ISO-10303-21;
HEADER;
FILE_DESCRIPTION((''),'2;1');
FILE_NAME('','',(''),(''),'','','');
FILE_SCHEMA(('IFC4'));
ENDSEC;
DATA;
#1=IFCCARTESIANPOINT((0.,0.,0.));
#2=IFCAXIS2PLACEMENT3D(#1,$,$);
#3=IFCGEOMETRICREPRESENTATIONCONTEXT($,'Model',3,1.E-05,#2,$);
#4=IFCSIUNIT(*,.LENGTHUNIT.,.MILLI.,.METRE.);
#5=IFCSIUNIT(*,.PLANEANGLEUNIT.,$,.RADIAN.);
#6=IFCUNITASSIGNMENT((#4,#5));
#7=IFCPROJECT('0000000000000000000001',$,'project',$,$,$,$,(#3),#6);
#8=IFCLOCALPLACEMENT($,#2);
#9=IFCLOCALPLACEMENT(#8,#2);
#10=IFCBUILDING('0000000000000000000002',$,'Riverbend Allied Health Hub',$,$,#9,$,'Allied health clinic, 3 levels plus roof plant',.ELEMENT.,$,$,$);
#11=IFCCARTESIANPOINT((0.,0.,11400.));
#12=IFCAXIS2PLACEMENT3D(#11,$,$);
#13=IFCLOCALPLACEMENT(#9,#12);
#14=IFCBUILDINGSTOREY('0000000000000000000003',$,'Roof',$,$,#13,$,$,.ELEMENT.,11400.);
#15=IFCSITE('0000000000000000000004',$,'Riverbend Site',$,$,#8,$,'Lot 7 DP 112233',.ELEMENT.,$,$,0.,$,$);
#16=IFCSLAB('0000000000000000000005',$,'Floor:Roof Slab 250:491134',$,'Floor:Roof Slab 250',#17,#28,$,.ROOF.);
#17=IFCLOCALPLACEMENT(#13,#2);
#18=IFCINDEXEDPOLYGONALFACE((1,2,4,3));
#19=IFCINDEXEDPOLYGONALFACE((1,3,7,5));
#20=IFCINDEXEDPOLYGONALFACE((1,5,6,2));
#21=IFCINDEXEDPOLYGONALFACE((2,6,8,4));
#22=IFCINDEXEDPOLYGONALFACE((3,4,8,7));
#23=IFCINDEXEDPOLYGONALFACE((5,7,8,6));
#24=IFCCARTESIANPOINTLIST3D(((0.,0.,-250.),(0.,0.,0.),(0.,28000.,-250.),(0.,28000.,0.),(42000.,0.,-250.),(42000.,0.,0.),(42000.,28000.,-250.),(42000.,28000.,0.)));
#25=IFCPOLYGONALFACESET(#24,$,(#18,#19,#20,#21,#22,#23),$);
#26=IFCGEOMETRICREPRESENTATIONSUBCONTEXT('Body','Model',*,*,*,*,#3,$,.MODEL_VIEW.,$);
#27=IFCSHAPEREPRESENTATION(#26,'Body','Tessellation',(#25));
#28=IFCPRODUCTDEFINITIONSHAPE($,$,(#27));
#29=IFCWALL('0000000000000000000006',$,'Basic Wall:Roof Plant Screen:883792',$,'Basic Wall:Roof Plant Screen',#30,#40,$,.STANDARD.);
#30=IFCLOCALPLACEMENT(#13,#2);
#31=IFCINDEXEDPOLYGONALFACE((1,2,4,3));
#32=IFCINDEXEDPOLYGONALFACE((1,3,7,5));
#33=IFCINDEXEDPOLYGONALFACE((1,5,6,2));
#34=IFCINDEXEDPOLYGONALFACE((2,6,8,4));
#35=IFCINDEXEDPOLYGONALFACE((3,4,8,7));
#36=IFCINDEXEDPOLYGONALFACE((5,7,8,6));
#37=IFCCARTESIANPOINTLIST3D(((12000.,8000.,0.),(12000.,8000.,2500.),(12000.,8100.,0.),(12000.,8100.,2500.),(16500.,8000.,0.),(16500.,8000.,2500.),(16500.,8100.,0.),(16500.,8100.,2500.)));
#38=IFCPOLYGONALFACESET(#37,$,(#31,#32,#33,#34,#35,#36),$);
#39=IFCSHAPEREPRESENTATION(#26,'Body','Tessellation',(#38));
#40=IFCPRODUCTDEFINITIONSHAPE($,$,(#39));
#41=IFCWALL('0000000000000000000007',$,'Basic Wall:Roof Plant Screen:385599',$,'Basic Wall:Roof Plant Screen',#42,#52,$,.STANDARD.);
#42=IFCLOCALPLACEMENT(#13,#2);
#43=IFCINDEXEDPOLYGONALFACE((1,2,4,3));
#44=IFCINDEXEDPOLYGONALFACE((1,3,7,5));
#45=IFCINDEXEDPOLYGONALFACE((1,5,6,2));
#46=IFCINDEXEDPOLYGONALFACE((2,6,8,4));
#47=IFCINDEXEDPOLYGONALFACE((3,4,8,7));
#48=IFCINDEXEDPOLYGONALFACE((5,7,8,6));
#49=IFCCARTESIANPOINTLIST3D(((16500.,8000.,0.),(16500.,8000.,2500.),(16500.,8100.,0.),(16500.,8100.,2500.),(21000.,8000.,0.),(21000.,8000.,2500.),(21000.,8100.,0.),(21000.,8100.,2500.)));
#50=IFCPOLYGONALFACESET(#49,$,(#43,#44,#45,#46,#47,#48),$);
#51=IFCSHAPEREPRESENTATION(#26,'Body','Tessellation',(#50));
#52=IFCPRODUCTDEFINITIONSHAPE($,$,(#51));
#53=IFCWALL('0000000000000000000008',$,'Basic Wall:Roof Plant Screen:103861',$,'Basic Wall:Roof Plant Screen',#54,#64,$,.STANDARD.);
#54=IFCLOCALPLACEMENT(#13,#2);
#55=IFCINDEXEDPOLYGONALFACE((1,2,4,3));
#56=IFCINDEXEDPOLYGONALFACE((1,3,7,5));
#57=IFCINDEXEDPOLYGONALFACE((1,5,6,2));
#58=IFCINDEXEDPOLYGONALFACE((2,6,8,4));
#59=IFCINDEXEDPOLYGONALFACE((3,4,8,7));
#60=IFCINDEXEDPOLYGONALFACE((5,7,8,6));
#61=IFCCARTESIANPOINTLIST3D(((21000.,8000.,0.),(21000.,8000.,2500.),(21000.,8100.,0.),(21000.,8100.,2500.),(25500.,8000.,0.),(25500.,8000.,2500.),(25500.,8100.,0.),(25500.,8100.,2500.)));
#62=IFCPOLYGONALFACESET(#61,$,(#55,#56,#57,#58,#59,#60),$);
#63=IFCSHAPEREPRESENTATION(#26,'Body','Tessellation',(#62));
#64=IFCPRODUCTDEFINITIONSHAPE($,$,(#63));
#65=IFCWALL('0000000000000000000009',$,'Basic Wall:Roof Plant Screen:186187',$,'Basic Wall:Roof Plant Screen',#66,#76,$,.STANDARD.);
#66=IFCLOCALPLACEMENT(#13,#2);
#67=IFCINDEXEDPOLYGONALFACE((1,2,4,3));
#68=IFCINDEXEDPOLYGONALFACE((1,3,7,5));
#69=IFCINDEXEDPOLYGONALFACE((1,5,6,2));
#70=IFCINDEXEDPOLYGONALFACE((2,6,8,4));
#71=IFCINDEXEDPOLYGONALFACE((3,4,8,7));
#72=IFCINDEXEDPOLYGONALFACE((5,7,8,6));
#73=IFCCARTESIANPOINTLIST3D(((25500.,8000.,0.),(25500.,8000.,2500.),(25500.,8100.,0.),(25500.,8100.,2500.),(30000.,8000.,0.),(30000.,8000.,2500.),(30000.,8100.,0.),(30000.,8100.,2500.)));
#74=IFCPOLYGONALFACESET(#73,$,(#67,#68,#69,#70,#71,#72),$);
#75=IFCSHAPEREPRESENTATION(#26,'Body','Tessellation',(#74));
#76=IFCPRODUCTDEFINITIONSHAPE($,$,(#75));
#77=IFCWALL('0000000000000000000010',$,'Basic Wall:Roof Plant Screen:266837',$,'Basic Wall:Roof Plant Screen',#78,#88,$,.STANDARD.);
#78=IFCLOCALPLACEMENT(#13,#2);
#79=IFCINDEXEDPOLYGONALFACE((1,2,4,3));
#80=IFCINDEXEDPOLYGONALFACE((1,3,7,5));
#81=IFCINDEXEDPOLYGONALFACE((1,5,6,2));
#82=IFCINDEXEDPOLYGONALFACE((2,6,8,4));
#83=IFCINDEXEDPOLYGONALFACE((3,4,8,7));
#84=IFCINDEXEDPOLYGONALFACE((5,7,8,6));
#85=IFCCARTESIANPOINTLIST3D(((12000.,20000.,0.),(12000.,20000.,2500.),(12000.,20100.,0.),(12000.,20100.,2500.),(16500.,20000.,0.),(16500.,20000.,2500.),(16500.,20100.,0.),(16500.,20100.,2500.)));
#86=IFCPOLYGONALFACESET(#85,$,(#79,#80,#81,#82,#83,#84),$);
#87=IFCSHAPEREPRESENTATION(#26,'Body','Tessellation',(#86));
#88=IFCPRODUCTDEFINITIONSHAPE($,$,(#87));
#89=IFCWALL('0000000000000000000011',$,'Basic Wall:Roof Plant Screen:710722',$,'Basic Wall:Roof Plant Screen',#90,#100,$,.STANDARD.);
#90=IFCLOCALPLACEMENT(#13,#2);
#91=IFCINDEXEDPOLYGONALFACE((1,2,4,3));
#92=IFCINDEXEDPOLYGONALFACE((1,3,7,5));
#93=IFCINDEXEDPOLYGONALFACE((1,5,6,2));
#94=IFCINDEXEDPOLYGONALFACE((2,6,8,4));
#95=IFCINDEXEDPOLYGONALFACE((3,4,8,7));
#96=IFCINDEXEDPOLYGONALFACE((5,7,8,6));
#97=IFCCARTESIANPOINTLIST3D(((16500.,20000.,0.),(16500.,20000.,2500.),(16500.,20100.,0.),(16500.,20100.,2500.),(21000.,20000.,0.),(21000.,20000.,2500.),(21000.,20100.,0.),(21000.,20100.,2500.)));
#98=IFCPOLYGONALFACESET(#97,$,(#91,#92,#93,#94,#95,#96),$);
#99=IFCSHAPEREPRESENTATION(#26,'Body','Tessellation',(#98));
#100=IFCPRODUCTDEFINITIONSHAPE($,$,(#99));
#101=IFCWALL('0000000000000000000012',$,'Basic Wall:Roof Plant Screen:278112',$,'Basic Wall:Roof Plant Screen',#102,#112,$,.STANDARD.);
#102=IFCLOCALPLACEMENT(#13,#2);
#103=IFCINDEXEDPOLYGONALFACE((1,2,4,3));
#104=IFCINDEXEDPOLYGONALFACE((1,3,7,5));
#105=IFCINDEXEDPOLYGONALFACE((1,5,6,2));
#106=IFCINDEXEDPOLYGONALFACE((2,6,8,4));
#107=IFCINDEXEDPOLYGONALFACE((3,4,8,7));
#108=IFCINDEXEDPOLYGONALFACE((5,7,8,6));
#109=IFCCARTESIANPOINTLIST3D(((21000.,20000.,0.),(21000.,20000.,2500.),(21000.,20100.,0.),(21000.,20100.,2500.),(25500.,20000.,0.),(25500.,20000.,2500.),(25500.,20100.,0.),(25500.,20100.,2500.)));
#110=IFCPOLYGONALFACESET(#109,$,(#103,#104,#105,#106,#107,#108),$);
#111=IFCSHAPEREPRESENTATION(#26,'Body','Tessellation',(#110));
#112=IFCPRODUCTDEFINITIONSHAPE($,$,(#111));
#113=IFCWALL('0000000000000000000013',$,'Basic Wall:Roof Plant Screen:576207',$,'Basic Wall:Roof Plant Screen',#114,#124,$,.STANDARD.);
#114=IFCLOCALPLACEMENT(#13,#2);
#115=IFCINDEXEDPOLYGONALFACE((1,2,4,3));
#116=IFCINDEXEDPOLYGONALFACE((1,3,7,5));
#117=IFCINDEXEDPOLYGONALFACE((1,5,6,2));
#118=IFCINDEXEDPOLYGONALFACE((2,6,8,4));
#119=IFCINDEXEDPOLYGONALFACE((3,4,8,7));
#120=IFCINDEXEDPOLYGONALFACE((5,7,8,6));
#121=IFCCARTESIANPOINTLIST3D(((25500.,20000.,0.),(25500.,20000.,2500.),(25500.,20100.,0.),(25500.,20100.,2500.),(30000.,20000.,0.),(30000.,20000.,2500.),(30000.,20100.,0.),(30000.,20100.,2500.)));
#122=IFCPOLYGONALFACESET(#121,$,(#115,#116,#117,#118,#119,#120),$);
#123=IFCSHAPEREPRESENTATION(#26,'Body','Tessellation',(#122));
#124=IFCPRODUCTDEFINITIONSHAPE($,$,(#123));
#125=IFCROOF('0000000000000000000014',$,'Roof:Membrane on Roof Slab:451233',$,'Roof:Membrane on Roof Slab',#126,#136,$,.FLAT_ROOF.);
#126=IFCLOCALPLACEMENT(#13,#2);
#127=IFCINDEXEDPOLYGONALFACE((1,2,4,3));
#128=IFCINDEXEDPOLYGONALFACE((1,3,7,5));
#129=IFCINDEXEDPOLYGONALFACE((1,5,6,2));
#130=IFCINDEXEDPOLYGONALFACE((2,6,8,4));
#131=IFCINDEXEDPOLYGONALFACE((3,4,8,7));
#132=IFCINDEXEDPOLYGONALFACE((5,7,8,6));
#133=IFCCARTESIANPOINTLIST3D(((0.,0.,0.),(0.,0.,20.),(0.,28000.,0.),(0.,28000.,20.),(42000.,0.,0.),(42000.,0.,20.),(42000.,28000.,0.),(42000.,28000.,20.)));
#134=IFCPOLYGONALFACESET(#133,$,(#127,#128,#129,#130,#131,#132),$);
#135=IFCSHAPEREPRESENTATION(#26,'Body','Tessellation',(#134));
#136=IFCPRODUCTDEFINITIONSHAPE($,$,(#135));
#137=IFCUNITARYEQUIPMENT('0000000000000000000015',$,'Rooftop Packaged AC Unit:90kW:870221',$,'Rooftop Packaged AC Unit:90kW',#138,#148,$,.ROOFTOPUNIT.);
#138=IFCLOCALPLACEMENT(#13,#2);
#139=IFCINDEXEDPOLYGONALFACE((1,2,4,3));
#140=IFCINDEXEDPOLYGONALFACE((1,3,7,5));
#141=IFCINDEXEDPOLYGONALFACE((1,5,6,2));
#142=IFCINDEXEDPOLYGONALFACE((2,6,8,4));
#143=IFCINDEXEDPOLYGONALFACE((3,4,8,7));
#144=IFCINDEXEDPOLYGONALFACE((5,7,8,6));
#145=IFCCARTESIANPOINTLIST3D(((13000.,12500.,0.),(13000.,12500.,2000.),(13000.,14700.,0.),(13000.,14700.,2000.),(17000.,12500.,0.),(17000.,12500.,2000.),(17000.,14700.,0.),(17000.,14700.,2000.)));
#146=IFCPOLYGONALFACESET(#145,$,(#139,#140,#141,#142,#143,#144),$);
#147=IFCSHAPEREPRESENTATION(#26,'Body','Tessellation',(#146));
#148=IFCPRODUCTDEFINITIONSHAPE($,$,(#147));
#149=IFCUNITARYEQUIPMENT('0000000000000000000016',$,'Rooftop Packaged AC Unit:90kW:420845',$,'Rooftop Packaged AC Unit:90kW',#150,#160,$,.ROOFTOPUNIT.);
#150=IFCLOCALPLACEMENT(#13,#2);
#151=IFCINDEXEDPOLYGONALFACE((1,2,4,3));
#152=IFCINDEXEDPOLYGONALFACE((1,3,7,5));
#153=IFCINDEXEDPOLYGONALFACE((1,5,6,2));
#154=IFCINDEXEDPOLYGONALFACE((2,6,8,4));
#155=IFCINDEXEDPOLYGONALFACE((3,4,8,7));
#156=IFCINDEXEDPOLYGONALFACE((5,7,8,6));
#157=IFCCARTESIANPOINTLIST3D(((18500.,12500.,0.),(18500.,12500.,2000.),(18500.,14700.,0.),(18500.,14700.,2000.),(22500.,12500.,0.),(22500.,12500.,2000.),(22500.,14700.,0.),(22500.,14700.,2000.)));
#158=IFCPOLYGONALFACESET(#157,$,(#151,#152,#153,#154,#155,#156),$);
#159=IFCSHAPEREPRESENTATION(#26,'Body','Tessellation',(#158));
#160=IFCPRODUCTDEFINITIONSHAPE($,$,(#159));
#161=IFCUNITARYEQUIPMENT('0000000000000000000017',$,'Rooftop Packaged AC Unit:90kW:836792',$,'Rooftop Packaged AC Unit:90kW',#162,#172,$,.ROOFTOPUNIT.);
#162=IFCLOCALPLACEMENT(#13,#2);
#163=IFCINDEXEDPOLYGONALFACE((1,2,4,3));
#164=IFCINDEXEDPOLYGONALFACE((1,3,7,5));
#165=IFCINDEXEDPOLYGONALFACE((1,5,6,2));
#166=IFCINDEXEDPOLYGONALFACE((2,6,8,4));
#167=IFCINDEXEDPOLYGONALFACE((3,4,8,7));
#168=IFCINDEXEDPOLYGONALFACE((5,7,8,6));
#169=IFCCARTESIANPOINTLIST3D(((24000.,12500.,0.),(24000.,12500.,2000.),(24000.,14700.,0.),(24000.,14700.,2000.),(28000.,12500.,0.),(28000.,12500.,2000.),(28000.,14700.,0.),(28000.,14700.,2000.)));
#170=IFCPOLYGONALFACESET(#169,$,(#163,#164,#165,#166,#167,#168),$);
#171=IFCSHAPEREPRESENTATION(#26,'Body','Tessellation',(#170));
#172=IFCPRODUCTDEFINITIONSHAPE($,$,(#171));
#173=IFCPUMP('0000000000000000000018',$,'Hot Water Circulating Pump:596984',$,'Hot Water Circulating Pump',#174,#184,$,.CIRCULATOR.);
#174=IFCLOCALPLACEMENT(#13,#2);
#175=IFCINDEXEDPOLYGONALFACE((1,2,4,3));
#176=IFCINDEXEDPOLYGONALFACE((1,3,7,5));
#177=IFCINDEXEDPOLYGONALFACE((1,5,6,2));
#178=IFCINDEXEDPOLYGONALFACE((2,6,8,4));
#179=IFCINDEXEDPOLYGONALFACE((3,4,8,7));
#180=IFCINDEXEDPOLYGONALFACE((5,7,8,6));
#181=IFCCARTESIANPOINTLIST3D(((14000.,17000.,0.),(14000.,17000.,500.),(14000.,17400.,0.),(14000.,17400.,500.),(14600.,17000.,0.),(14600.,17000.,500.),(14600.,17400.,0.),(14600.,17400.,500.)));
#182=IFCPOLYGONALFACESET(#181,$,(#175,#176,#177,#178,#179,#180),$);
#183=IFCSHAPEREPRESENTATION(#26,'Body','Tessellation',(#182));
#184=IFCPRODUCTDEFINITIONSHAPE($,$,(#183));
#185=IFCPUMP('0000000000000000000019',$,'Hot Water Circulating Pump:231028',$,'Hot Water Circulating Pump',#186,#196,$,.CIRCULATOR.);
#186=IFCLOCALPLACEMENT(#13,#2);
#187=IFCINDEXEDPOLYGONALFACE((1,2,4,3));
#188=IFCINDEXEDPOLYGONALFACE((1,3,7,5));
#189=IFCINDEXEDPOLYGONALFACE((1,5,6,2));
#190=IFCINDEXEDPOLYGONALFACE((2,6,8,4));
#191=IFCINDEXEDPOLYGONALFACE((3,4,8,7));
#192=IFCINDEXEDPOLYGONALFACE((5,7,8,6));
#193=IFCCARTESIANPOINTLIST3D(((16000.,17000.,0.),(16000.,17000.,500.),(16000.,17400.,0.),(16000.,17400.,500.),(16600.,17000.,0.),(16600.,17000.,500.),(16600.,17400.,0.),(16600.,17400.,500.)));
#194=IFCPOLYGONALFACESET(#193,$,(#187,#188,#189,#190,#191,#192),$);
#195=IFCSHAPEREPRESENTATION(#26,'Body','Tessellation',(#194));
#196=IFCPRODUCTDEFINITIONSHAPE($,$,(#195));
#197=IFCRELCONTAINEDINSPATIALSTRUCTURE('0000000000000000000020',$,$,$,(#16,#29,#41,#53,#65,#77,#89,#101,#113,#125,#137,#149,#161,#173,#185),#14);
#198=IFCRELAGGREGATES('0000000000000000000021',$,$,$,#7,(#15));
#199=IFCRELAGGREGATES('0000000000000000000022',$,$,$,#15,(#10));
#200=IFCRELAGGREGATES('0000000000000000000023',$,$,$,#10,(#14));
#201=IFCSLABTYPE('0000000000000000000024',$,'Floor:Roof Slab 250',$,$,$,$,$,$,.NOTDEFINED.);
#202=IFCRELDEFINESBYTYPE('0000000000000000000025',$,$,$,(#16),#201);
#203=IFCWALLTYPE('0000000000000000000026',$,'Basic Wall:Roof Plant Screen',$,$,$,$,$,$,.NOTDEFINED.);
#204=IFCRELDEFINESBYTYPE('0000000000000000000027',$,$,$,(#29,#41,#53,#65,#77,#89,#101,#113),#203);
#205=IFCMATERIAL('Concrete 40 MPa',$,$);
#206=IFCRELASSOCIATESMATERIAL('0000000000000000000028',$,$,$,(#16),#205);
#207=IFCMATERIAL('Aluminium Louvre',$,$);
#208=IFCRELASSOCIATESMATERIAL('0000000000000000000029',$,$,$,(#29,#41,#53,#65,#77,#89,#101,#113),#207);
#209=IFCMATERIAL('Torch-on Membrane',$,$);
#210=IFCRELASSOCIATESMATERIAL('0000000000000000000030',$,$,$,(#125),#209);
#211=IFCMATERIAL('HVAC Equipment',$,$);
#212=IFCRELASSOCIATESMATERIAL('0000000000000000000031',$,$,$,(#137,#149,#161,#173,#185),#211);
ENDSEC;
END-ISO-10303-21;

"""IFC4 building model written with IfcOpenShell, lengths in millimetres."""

from ifc_helpers import new_model, si_unit, frame, frame_2d, origin, place, context, subcontext, project, spatial, rectangle, extrude, material, type_object, element, save


model = new_model("IFC4")

# Units and contexts
model_context = context("Model", 3, precision=1e-05, world=origin())
body_context = subcontext(model_context, "Body", "Model", "MODEL_VIEW")
ifc_project = project(units=[si_unit("LENGTHUNIT", "METRE", prefix="MILLI"), si_unit("PLANEANGLEUNIT", "RADIAN")], contexts=[model_context])

# Site, building, storey
site_placement = place(None, origin())
site = spatial("IfcSite", under=ifc_project, at=site_placement, Name="Riverbend Site", LongName="Lot 7 DP 112233", CompositionType="ELEMENT", RefElevation=0.0)
building_placement = place(site_placement, origin())
building = spatial("IfcBuilding", under=site, at=building_placement, Name="Riverbend Allied Health Hub", LongName="Allied health clinic, 3 levels plus roof plant", CompositionType="ELEMENT")
storey_placement = place(building_placement, frame((0.0, 0.0, 11400.0)))
storey = spatial("IfcBuildingStorey", under=building, at=storey_placement, Name="Roof", CompositionType="ELEMENT", Elevation=11400.0)

# Slab
ifc_material_1 = material(Name="Concrete 40 MPa")
slab_type = type_object("IfcSlabType", Name="Floor:Roof Slab 250", PredefinedType="NOTDEFINED")
slab_placement = place(storey_placement, frame((0.0, 0.0, -250.0)))
element("IfcSlab", 1, at=slab_placement, inside=storey, type_object=slab_type, material=ifc_material_1, Name="Floor:Roof Slab 250:491134", ObjectType="Floor:Roof Slab 250", PredefinedType="ROOF", context=body_context, shape_type="SweptSolid", body=[
    extrude(rectangle(XDim=42000.0, YDim=28000.0, at=frame_2d((21000.0, 14000.0))), origin(), (0.0, 0.0, 1.0), 250.0),
])

# Walls
ifc_material_2 = material(Name="Aluminium Louvre")
wall_type = type_object("IfcWallType", Name="Basic Wall:Roof Plant Screen", PredefinedType="NOTDEFINED")
for number, where, name in (
    (2, (12000.0, 8000.0, 0.0), "Basic Wall:Roof Plant Screen:883792"),
    (3, (16500.0, 8000.0, 0.0), "Basic Wall:Roof Plant Screen:385599"),
    (4, (21000.0, 8000.0, 0.0), "Basic Wall:Roof Plant Screen:103861"),
    (5, (25500.0, 8000.0, 0.0), "Basic Wall:Roof Plant Screen:186187"),
    (6, (12000.0, 20000.0, 0.0), "Basic Wall:Roof Plant Screen:266837"),
    (7, (16500.0, 20000.0, 0.0), "Basic Wall:Roof Plant Screen:710722"),
    (8, (21000.0, 20000.0, 0.0), "Basic Wall:Roof Plant Screen:278112"),
    (9, (25500.0, 20000.0, 0.0), "Basic Wall:Roof Plant Screen:576207"),
):
    element("IfcWall", number, at=place(storey_placement, frame(where)), inside=storey, type_object=wall_type, material=ifc_material_2, Name=name, ObjectType="Basic Wall:Roof Plant Screen", PredefinedType="STANDARD", context=body_context, shape_type="SweptSolid", body=[
        extrude(rectangle(XDim=4500.0, YDim=100.0, at=frame_2d((2250.0, 50.0))), origin(), (0.0, 0.0, 1.0), 2500.0),
    ])

# Roof
ifc_material_3 = material(Name="Torch-on Membrane")
roof_placement = place(storey_placement, origin())
element("IfcRoof", 10, at=roof_placement, inside=storey, material=ifc_material_3, Name="Roof:Membrane on Roof Slab:451233", ObjectType="Roof:Membrane on Roof Slab", PredefinedType="FLAT_ROOF", context=body_context, shape_type="SweptSolid", body=[
    extrude(rectangle(XDim=42000.0, YDim=28000.0, at=frame_2d((21000.0, 14000.0))), origin(), (0.0, 0.0, 1.0), 20.0),
])

# Unitary equipment
ifc_material_4 = material(Name="HVAC Equipment")
for number, where, name in (
    (11, (13000.0, 12500.0, 0.0), "Rooftop Packaged AC Unit:90kW:870221"),
    (12, (18500.0, 12500.0, 0.0), "Rooftop Packaged AC Unit:90kW:420845"),
    (13, (24000.0, 12500.0, 0.0), "Rooftop Packaged AC Unit:90kW:836792"),
):
    element("IfcUnitaryEquipment", number, at=place(storey_placement, frame(where)), inside=storey, material=ifc_material_4, Name=name, ObjectType="Rooftop Packaged AC Unit:90kW", PredefinedType="ROOFTOPUNIT", context=body_context, shape_type="SweptSolid", body=[
        extrude(rectangle(XDim=4000.0, YDim=2200.0, at=frame_2d((2000.0, 1100.0))), origin(), (0.0, 0.0, 1.0), 2000.0),
    ])

# Pumps
for number, where, name in (
    (14, (14000.0, 17000.0, 0.0), "Hot Water Circulating Pump:596984"),
    (15, (16000.0, 17000.0, 0.0), "Hot Water Circulating Pump:231028"),
):
    element("IfcPump", number, at=place(storey_placement, frame(where)), inside=storey, material=ifc_material_4, Name=name, ObjectType="Hot Water Circulating Pump", PredefinedType="CIRCULATOR", context=body_context, shape_type="SweptSolid", body=[
        extrude(rectangle(XDim=600.0, YDim=400.0, at=frame_2d((300.0, 200.0))), origin(), (0.0, 0.0, 1.0), 500.0),
    ])

save(model, "model.ifc")
